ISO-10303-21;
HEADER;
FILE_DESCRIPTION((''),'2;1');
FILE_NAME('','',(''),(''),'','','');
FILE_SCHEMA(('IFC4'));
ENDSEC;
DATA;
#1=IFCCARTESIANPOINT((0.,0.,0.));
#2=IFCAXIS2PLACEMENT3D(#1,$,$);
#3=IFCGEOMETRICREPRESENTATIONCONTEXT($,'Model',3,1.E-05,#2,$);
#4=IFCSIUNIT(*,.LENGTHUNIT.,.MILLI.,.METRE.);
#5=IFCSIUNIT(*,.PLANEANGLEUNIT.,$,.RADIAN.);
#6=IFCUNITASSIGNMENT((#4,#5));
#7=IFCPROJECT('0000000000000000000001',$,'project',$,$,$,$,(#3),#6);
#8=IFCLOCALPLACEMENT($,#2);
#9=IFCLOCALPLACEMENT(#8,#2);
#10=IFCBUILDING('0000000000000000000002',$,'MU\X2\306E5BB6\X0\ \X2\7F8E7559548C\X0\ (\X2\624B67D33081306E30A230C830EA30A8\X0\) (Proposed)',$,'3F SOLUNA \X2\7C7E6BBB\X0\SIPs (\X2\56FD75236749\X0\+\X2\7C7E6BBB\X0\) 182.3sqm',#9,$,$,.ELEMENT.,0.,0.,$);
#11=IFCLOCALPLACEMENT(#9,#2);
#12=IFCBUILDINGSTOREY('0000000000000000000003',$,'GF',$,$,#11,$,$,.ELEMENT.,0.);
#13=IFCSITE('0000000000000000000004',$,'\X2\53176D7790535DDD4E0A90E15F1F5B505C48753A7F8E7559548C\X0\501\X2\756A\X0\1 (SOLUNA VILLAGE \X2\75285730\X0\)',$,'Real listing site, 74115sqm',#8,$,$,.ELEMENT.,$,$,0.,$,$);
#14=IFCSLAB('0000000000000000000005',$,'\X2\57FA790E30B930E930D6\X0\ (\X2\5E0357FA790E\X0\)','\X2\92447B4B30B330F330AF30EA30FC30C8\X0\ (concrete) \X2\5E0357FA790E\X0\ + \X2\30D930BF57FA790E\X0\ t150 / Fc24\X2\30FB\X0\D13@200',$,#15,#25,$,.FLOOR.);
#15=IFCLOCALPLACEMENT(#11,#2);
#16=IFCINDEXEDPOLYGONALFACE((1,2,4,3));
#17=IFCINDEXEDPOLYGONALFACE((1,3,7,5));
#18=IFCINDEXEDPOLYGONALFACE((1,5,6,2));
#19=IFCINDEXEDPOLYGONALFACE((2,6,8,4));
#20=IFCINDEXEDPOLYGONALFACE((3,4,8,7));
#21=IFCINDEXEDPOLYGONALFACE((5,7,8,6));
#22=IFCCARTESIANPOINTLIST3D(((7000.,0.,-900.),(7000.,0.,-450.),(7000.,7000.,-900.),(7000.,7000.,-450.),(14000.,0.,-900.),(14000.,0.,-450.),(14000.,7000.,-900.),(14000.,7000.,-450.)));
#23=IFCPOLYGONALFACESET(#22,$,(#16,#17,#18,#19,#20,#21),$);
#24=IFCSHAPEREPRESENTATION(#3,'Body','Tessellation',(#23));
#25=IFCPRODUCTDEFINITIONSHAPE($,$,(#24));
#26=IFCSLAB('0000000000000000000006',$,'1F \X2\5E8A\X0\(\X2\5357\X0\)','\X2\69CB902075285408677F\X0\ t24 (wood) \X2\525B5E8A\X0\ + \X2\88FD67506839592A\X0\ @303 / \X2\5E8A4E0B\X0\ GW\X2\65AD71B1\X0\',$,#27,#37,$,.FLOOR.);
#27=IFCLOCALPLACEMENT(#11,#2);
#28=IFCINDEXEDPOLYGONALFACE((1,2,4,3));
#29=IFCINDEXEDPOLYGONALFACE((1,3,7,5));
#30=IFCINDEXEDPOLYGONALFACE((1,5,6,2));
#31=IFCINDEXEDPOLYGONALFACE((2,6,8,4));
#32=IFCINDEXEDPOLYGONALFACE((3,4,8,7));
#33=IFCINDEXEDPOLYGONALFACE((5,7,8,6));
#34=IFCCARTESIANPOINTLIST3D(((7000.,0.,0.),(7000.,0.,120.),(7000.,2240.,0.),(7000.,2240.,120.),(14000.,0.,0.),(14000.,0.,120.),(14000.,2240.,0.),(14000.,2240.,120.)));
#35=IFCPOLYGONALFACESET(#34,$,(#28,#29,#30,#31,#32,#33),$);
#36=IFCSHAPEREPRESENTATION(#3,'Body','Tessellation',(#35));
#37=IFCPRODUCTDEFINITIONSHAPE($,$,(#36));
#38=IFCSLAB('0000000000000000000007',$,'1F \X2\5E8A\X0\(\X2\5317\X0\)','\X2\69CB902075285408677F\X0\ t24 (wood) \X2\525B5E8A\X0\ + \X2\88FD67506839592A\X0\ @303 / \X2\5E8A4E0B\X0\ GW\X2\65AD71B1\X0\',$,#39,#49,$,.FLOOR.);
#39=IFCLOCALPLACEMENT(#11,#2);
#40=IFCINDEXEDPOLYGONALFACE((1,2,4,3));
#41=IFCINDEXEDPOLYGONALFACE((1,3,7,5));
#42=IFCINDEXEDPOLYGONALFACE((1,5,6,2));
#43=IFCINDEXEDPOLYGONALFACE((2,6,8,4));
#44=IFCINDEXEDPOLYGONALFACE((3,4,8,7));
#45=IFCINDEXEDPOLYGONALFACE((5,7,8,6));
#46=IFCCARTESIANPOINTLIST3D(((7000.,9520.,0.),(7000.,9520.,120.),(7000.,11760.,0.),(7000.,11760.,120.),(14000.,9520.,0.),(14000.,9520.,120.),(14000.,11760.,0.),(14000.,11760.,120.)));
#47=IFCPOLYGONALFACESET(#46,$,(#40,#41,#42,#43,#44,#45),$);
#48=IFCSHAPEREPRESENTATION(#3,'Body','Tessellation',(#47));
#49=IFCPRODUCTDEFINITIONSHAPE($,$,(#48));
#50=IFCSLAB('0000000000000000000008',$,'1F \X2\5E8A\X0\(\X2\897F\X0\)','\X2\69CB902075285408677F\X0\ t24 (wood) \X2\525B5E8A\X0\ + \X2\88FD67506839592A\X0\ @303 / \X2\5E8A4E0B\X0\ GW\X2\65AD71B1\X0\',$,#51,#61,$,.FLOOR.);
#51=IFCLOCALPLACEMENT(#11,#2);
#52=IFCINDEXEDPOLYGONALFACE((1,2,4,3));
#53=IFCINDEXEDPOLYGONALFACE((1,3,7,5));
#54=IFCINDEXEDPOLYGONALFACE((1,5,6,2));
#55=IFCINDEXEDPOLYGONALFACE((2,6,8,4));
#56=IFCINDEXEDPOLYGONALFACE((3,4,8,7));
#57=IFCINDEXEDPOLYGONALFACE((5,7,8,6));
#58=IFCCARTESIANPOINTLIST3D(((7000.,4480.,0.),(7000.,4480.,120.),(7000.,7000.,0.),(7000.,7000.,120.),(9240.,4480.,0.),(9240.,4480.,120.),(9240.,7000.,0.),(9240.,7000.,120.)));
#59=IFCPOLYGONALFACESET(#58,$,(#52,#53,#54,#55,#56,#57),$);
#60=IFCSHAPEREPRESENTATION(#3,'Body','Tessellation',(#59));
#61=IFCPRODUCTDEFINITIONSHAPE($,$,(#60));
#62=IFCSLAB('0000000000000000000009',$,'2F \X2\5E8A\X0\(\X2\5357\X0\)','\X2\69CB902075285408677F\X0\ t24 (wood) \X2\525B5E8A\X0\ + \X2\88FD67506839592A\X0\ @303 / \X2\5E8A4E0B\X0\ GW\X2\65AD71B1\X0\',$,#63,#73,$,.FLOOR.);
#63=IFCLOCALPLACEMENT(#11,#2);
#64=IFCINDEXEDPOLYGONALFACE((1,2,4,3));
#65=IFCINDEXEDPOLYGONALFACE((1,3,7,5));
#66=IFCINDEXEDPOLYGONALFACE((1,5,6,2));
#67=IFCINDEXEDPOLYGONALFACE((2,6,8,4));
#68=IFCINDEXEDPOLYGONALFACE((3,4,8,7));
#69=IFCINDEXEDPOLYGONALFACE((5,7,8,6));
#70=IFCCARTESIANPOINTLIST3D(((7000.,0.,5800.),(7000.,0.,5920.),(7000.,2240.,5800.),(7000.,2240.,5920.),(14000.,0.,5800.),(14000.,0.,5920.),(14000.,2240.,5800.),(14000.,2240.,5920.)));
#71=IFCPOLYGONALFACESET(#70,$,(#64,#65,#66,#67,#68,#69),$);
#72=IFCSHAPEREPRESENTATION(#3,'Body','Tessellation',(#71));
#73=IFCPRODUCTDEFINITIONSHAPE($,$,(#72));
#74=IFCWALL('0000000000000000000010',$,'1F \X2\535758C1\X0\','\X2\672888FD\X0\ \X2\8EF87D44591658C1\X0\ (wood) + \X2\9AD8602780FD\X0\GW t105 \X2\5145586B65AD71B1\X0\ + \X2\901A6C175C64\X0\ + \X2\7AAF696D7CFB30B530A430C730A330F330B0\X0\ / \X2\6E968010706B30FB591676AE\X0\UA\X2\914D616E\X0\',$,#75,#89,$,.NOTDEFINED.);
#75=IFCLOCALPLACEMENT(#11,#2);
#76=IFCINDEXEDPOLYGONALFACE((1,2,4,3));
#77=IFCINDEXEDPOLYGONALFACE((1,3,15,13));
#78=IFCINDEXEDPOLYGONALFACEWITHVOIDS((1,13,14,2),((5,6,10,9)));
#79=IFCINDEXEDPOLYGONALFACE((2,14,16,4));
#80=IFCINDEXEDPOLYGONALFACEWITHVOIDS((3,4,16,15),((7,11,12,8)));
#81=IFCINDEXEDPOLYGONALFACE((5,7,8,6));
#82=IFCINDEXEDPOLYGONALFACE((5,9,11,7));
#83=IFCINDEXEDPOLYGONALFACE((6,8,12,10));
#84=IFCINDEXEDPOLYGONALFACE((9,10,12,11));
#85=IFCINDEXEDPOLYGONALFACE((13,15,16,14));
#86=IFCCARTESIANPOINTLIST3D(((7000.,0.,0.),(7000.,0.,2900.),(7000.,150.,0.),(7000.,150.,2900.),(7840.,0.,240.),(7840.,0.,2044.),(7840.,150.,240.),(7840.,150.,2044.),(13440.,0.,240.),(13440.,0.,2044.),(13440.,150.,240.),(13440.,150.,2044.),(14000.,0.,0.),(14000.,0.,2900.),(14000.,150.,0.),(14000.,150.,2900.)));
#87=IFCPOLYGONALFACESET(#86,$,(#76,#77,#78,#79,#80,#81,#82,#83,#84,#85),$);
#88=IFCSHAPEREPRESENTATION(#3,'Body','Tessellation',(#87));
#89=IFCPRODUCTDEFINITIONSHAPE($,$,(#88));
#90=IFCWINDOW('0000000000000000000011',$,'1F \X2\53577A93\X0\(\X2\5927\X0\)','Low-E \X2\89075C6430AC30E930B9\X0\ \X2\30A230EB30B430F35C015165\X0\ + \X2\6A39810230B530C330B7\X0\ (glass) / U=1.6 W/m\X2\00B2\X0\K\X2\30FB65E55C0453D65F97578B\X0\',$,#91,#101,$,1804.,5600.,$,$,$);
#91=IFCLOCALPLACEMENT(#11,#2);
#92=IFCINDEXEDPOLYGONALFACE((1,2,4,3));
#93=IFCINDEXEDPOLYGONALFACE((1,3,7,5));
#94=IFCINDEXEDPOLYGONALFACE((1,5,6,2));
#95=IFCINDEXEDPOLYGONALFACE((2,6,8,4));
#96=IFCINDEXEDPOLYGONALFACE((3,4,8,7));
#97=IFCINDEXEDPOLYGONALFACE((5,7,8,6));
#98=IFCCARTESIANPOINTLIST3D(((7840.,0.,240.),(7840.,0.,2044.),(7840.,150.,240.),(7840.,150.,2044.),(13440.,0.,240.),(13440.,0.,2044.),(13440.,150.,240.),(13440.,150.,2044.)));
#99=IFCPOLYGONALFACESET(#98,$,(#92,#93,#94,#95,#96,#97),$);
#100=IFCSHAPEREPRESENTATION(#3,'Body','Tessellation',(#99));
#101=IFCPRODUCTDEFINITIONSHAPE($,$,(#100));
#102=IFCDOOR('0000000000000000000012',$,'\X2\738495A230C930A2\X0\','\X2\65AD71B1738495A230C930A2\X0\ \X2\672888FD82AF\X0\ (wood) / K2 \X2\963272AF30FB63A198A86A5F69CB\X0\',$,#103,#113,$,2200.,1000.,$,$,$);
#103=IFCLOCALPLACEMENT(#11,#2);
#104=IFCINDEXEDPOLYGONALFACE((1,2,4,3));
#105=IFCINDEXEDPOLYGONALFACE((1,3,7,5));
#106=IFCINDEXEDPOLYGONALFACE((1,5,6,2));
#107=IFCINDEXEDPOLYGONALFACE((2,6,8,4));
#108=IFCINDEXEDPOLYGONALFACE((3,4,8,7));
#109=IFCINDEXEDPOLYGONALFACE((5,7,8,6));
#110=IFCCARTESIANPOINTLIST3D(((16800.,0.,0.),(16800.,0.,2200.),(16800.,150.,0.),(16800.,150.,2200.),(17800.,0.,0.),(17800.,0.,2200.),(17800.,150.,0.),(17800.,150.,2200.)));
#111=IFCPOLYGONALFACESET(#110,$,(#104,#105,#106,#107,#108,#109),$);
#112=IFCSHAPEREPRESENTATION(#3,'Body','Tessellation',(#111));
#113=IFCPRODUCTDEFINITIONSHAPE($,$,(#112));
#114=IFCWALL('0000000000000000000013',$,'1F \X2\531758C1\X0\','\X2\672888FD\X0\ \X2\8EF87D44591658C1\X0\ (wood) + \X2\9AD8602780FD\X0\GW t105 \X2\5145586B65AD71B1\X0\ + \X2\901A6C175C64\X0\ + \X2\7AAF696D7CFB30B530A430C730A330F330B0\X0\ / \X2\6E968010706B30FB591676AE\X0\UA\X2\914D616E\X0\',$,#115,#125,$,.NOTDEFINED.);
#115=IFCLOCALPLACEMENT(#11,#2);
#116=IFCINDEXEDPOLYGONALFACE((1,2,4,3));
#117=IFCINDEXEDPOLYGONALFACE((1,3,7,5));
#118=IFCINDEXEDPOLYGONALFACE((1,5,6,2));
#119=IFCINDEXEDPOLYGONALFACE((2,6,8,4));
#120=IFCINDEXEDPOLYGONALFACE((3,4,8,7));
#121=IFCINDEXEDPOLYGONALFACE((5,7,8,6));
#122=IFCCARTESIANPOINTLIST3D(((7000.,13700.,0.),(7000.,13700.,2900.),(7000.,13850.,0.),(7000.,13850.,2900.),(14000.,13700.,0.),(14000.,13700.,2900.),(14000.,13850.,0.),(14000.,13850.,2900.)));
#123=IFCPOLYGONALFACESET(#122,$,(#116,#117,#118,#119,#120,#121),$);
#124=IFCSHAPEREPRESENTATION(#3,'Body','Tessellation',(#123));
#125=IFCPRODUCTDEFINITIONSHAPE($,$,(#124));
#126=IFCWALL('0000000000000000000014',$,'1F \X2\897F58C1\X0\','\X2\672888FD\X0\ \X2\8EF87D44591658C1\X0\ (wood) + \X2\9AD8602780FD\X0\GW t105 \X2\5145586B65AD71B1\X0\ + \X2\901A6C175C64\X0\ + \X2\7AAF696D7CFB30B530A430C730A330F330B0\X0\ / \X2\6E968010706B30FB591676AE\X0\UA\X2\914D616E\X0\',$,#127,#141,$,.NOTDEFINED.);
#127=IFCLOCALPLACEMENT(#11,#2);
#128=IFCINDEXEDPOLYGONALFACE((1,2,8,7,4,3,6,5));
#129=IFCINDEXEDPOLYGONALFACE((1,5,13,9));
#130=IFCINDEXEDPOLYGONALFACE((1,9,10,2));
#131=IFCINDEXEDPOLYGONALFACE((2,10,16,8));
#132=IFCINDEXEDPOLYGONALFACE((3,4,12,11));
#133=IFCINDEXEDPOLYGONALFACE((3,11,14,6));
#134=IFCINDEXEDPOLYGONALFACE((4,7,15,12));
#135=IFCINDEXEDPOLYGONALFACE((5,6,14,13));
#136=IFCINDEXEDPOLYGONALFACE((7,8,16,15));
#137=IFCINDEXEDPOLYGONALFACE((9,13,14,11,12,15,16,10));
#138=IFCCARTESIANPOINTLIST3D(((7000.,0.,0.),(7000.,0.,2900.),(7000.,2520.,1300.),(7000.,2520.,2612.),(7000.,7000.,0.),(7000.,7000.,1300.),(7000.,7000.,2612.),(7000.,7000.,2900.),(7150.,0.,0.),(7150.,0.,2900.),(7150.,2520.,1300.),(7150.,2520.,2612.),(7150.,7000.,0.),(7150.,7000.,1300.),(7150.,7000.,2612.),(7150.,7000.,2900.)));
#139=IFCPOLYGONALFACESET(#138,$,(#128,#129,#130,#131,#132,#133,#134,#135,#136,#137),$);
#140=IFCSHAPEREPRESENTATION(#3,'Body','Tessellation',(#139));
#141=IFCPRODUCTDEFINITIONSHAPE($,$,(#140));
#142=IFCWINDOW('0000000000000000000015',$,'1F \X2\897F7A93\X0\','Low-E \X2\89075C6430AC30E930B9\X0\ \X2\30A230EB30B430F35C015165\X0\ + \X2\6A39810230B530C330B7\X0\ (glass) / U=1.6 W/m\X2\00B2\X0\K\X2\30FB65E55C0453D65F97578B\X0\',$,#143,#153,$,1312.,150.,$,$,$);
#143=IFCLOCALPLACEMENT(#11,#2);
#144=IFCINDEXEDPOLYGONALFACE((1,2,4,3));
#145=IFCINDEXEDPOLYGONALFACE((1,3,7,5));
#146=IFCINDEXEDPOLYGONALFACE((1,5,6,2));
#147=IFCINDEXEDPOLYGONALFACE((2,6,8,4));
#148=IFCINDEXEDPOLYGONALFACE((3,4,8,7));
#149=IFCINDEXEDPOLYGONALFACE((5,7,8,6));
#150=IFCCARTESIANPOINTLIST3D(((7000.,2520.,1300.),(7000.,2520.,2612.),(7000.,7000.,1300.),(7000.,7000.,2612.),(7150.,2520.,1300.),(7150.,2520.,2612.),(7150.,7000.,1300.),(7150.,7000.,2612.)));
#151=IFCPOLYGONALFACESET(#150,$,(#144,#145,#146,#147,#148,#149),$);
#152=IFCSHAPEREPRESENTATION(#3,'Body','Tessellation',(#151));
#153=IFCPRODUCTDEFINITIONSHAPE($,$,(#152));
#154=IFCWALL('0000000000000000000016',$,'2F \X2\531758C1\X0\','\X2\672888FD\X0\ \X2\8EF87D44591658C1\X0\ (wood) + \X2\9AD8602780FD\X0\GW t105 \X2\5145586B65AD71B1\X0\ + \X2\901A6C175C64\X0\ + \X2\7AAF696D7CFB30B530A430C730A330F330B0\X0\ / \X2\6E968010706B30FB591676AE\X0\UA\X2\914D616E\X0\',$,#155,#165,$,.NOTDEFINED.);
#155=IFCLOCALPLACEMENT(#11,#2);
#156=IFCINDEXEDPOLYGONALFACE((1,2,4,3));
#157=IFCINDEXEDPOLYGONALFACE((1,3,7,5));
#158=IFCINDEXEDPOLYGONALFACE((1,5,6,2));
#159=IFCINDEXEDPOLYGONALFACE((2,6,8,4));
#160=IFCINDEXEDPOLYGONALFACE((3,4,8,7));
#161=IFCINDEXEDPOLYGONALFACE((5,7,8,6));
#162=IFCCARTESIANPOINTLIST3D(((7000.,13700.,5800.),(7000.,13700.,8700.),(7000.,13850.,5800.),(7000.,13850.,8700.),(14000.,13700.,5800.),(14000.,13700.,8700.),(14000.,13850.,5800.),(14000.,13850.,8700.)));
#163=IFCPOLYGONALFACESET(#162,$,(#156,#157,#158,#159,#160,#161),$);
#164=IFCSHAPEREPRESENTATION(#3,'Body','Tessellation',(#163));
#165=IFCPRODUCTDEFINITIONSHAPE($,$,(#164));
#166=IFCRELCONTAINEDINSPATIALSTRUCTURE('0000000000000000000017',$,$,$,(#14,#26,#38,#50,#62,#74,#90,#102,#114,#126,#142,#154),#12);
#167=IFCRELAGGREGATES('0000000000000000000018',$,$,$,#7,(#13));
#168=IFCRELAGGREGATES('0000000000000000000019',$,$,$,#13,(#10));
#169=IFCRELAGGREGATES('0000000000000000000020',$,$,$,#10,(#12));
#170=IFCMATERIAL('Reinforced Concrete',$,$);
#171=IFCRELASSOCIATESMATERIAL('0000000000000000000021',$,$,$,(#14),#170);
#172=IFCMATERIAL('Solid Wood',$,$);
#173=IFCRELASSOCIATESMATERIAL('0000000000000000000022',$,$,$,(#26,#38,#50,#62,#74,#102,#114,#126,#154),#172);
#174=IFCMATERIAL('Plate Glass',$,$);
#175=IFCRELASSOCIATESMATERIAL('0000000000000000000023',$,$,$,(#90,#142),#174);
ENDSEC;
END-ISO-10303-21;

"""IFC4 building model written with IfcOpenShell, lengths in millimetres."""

from ifc_helpers import new_model, si_unit, frame, frame_2d, origin, place, context, project, spatial, rectangle, extrude, material, element, fill, save


model = new_model("IFC4")

# Units and contexts
model_context = context("Model", 3, precision=1e-05, world=origin())
ifc_project = project(units=[si_unit("LENGTHUNIT", "METRE", prefix="MILLI"), si_unit("PLANEANGLEUNIT", "RADIAN")], contexts=[model_context])

# Site, building, storey
site_placement = place(None, origin())
site = spatial("IfcSite", under=ifc_project, at=site_placement, Name="北海道川上郡弟子屈町美留和501番1 (SOLUNA VILLAGE 用地)", ObjectType="Real listing site, 74115sqm", CompositionType="ELEMENT", RefElevation=0.0)
building_placement = place(site_placement, origin())
building = spatial("IfcBuilding", under=site, at=building_placement, Name="MUの家 美留和 (手染めのアトリエ) (Proposed)", ObjectType="3F SOLUNA 籾殻SIPs (国産杉+籾殻) 182.3sqm", CompositionType="ELEMENT", ElevationOfRefHeight=0.0, ElevationOfTerrain=0.0)
storey_placement = place(building_placement, origin())
storey = spatial("IfcBuildingStorey", under=building, at=storey_placement, Name="GF", CompositionType="ELEMENT", Elevation=0.0)

# Slabs
ifc_material_1 = material(Name="Reinforced Concrete")
slab_1_placement = place(storey_placement, frame((3500.0, 0.0, -450.0)))
element("IfcSlab", 1, at=slab_1_placement, inside=storey, material=ifc_material_1, Name="基礎スラブ (布基礎)", Description="鉄筋コンクリート (concrete) 布基礎 + ベタ基礎 t150 / Fc24・D13@200", PredefinedType="FLOOR", context=model_context, shape_type="SweptSolid", body=[
    extrude(rectangle(XDim=7000.0, YDim=7000.0, at=frame_2d((3500.0, 3500.0))), frame((3500.0, 0.0, -450.0)), (0.0, 0.0, 1.0), 450.0),
])
ifc_material_2 = material(Name="Solid Wood")
slab_2_placement = place(storey_placement, frame((3500.0, 0.0, 0.0)))
element("IfcSlab", 2, at=slab_2_placement, inside=storey, material=ifc_material_2, Name="1F 床(南)", Description="構造用合板 t24 (wood) 剛床 + 製材根太 @303 / 床下 GW断熱", PredefinedType="FLOOR", context=model_context, shape_type="SweptSolid", body=[
    extrude(rectangle(XDim=7000.0, YDim=2240.0, at=frame_2d((3500.0, 1120.0))), frame((3500.0, 0.0, 0.0)), (0.0, 0.0, 1.0), 120.0),
])
slab_3_placement = place(storey_placement, frame((3500.0, 4760.0, 0.0)))
element("IfcSlab", 3, at=slab_3_placement, inside=storey, material=ifc_material_2, Name="1F 床(北)", Description="構造用合板 t24 (wood) 剛床 + 製材根太 @303 / 床下 GW断熱", PredefinedType="FLOOR", context=model_context, shape_type="SweptSolid", body=[
    extrude(rectangle(XDim=7000.0, YDim=2240.0, at=frame_2d((3500.0, 1120.0))), frame((3500.0, 4760.0, 0.0)), (0.0, 0.0, 1.0), 120.0),
])
slab_4_placement = place(storey_placement, frame((3500.0, 2240.0, 0.0)))
element("IfcSlab", 4, at=slab_4_placement, inside=storey, material=ifc_material_2, Name="1F 床(西)", Description="構造用合板 t24 (wood) 剛床 + 製材根太 @303 / 床下 GW断熱", PredefinedType="FLOOR", context=model_context, shape_type="SweptSolid", body=[
    extrude(rectangle(XDim=2240.0, YDim=2520.0, at=frame_2d((1120.0, 1260.0))), frame((3500.0, 2240.0, 0.0)), (0.0, 0.0, 1.0), 120.0),
])
slab_5_placement = place(storey_placement, frame((3500.0, 0.0, 2900.0)))
element("IfcSlab", 5, at=slab_5_placement, inside=storey, material=ifc_material_2, Name="2F 床(南)", Description="構造用合板 t24 (wood) 剛床 + 製材根太 @303 / 床下 GW断熱", PredefinedType="FLOOR", context=model_context, shape_type="SweptSolid", body=[
    extrude(rectangle(XDim=7000.0, YDim=2240.0, at=frame_2d((3500.0, 1120.0))), frame((3500.0, 0.0, 2900.0)), (0.0, 0.0, 1.0), 120.0),
])

# Wall, openings, window, door
wall_1_placement = place(storey_placement, frame((3500.0, 0.0, 0.0)))
wall_1 = element("IfcWall", 6, at=wall_1_placement, inside=storey, material=ifc_material_2, Name="1F 南壁", Description="木製 軸組外壁 (wood) + 高性能GW t105 充填断熱 + 通気層 + 窯業系サイディング / 準耐火・外皮UA配慮", PredefinedType="NOTDEFINED", context=model_context, shape_type="SweptSolid", body=[
    extrude(rectangle(XDim=7000.0, YDim=150.0, at=frame_2d((3500.0, 75.0))), frame((3500.0, 0.0, 0.0)), (0.0, 0.0, 1.0), 2900.0),
])
opening_1_placement = place(storey_placement, frame((3920.0, 0.0, 120.0)))
opening_1 = element("IfcOpeningElement", 7, at=opening_1_placement, cuts=wall_1, PredefinedType="NOTDEFINED", context=model_context, shape_type="SweptSolid", body=[
    extrude(rectangle(XDim=5600.0, YDim=150.0, at=frame_2d((2800.0, 75.0))), frame((3920.0, 0.0, 120.0)), (0.0, 0.0, 1.0), 1804.0),
])
opening_2_placement = place(storey_placement, frame((8400.0, 0.0, 0.0)))
opening_2 = element("IfcOpeningElement", 8, at=opening_2_placement, cuts=wall_1, PredefinedType="NOTDEFINED", context=model_context, shape_type="SweptSolid", body=[
    extrude(rectangle(XDim=1000.0, YDim=150.0, at=frame_2d((500.0, 75.0))), frame((8400.0, 0.0, 0.0)), (0.0, 0.0, 1.0), 2200.0),
])
ifc_material_3 = material(Name="Plate Glass")
window_1_placement = place(storey_placement, frame((3920.0, 0.0, 120.0)))
window_1 = element("IfcWindow", 9, at=window_1_placement, inside=storey, material=ifc_material_3, Name="1F 南窓(大)", Description="Low-E 複層ガラス アルゴン封入 + 樹脂サッシ (glass) / U=1.6 W/m²K・日射取得型", OverallHeight=1804.0, OverallWidth=5600.0, context=model_context, shape_type="SweptSolid", body=[
    extrude(rectangle(XDim=5600.0, YDim=150.0, at=frame_2d((2800.0, 75.0))), frame((3920.0, 0.0, 120.0)), (0.0, 0.0, 1.0), 1804.0),
])
fill(opening_1, window_1)
door_placement = place(storey_placement, frame((8400.0, 0.0, 0.0)))
door = element("IfcDoor", 10, at=door_placement, inside=storey, material=ifc_material_2, Name="玄関ドア", Description="断熱玄関ドア 木製芯 (wood) / K2 防犯・採風機構", OverallHeight=2200.0, OverallWidth=1000.0, context=model_context, shape_type="SweptSolid", body=[
    extrude(rectangle(XDim=1000.0, YDim=150.0, at=frame_2d((500.0, 75.0))), frame((8400.0, 0.0, 0.0)), (0.0, 0.0, 1.0), 2200.0),
])
fill(opening_2, door)

# Wall
wall_2_placement = place(storey_placement, frame((3500.0, 6850.0, 0.0)))
element("IfcWall", 11, at=wall_2_placement, inside=storey, material=ifc_material_2, Name="1F 北壁", Description="木製 軸組外壁 (wood) + 高性能GW t105 充填断熱 + 通気層 + 窯業系サイディング / 準耐火・外皮UA配慮", PredefinedType="NOTDEFINED", context=model_context, shape_type="SweptSolid", body=[
    extrude(rectangle(XDim=7000.0, YDim=150.0, at=frame_2d((3500.0, 75.0))), frame((3500.0, 6850.0, 0.0)), (0.0, 0.0, 1.0), 2900.0),
])

# Wall, opening, window
wall_3_placement = place(storey_placement, frame((3500.0, 0.0, 0.0)))
wall_3 = element("IfcWall", 12, at=wall_3_placement, inside=storey, material=ifc_material_2, Name="1F 西壁", Description="木製 軸組外壁 (wood) + 高性能GW t105 充填断熱 + 通気層 + 窯業系サイディング / 準耐火・外皮UA配慮", PredefinedType="NOTDEFINED", context=model_context, shape_type="SweptSolid", body=[
    extrude(rectangle(XDim=150.0, YDim=7000.0, at=frame_2d((75.0, 3500.0))), frame((3500.0, 0.0, 0.0)), (0.0, 0.0, 1.0), 2900.0),
])
opening_3_placement = place(storey_placement, frame((3500.0, 1260.0, 650.0)))
opening_3 = element("IfcOpeningElement", 13, at=opening_3_placement, cuts=wall_3, PredefinedType="NOTDEFINED", context=model_context, shape_type="SweptSolid", body=[
    extrude(rectangle(XDim=150.0, YDim=4480.0, at=frame_2d((75.0, 2240.0))), frame((3500.0, 1260.0, 650.0)), (0.0, 0.0, 1.0), 1312.0),
])
window_2_placement = place(storey_placement, frame((3500.0, 1260.0, 650.0)))
window_2 = element("IfcWindow", 14, at=window_2_placement, inside=storey, material=ifc_material_3, Name="1F 西窓", Description="Low-E 複層ガラス アルゴン封入 + 樹脂サッシ (glass) / U=1.6 W/m²K・日射取得型", OverallHeight=1312.0, OverallWidth=150.0, context=model_context, shape_type="SweptSolid", body=[
    extrude(rectangle(XDim=150.0, YDim=4480.0, at=frame_2d((75.0, 2240.0))), frame((3500.0, 1260.0, 650.0)), (0.0, 0.0, 1.0), 1312.0),
])
fill(opening_3, window_2)

# Wall
wall_4_placement = place(storey_placement, frame((3500.0, 6850.0, 2900.0)))
element("IfcWall", 15, at=wall_4_placement, inside=storey, material=ifc_material_2, Name="2F 北壁", Description="木製 軸組外壁 (wood) + 高性能GW t105 充填断熱 + 通気層 + 窯業系サイディング / 準耐火・外皮UA配慮", PredefinedType="NOTDEFINED", context=model_context, shape_type="SweptSolid", body=[
    extrude(rectangle(XDim=7000.0, YDim=150.0, at=frame_2d((3500.0, 75.0))), frame((3500.0, 6850.0, 2900.0)), (0.0, 0.0, 1.0), 2900.0),
])

save(model, "model.ifc")
